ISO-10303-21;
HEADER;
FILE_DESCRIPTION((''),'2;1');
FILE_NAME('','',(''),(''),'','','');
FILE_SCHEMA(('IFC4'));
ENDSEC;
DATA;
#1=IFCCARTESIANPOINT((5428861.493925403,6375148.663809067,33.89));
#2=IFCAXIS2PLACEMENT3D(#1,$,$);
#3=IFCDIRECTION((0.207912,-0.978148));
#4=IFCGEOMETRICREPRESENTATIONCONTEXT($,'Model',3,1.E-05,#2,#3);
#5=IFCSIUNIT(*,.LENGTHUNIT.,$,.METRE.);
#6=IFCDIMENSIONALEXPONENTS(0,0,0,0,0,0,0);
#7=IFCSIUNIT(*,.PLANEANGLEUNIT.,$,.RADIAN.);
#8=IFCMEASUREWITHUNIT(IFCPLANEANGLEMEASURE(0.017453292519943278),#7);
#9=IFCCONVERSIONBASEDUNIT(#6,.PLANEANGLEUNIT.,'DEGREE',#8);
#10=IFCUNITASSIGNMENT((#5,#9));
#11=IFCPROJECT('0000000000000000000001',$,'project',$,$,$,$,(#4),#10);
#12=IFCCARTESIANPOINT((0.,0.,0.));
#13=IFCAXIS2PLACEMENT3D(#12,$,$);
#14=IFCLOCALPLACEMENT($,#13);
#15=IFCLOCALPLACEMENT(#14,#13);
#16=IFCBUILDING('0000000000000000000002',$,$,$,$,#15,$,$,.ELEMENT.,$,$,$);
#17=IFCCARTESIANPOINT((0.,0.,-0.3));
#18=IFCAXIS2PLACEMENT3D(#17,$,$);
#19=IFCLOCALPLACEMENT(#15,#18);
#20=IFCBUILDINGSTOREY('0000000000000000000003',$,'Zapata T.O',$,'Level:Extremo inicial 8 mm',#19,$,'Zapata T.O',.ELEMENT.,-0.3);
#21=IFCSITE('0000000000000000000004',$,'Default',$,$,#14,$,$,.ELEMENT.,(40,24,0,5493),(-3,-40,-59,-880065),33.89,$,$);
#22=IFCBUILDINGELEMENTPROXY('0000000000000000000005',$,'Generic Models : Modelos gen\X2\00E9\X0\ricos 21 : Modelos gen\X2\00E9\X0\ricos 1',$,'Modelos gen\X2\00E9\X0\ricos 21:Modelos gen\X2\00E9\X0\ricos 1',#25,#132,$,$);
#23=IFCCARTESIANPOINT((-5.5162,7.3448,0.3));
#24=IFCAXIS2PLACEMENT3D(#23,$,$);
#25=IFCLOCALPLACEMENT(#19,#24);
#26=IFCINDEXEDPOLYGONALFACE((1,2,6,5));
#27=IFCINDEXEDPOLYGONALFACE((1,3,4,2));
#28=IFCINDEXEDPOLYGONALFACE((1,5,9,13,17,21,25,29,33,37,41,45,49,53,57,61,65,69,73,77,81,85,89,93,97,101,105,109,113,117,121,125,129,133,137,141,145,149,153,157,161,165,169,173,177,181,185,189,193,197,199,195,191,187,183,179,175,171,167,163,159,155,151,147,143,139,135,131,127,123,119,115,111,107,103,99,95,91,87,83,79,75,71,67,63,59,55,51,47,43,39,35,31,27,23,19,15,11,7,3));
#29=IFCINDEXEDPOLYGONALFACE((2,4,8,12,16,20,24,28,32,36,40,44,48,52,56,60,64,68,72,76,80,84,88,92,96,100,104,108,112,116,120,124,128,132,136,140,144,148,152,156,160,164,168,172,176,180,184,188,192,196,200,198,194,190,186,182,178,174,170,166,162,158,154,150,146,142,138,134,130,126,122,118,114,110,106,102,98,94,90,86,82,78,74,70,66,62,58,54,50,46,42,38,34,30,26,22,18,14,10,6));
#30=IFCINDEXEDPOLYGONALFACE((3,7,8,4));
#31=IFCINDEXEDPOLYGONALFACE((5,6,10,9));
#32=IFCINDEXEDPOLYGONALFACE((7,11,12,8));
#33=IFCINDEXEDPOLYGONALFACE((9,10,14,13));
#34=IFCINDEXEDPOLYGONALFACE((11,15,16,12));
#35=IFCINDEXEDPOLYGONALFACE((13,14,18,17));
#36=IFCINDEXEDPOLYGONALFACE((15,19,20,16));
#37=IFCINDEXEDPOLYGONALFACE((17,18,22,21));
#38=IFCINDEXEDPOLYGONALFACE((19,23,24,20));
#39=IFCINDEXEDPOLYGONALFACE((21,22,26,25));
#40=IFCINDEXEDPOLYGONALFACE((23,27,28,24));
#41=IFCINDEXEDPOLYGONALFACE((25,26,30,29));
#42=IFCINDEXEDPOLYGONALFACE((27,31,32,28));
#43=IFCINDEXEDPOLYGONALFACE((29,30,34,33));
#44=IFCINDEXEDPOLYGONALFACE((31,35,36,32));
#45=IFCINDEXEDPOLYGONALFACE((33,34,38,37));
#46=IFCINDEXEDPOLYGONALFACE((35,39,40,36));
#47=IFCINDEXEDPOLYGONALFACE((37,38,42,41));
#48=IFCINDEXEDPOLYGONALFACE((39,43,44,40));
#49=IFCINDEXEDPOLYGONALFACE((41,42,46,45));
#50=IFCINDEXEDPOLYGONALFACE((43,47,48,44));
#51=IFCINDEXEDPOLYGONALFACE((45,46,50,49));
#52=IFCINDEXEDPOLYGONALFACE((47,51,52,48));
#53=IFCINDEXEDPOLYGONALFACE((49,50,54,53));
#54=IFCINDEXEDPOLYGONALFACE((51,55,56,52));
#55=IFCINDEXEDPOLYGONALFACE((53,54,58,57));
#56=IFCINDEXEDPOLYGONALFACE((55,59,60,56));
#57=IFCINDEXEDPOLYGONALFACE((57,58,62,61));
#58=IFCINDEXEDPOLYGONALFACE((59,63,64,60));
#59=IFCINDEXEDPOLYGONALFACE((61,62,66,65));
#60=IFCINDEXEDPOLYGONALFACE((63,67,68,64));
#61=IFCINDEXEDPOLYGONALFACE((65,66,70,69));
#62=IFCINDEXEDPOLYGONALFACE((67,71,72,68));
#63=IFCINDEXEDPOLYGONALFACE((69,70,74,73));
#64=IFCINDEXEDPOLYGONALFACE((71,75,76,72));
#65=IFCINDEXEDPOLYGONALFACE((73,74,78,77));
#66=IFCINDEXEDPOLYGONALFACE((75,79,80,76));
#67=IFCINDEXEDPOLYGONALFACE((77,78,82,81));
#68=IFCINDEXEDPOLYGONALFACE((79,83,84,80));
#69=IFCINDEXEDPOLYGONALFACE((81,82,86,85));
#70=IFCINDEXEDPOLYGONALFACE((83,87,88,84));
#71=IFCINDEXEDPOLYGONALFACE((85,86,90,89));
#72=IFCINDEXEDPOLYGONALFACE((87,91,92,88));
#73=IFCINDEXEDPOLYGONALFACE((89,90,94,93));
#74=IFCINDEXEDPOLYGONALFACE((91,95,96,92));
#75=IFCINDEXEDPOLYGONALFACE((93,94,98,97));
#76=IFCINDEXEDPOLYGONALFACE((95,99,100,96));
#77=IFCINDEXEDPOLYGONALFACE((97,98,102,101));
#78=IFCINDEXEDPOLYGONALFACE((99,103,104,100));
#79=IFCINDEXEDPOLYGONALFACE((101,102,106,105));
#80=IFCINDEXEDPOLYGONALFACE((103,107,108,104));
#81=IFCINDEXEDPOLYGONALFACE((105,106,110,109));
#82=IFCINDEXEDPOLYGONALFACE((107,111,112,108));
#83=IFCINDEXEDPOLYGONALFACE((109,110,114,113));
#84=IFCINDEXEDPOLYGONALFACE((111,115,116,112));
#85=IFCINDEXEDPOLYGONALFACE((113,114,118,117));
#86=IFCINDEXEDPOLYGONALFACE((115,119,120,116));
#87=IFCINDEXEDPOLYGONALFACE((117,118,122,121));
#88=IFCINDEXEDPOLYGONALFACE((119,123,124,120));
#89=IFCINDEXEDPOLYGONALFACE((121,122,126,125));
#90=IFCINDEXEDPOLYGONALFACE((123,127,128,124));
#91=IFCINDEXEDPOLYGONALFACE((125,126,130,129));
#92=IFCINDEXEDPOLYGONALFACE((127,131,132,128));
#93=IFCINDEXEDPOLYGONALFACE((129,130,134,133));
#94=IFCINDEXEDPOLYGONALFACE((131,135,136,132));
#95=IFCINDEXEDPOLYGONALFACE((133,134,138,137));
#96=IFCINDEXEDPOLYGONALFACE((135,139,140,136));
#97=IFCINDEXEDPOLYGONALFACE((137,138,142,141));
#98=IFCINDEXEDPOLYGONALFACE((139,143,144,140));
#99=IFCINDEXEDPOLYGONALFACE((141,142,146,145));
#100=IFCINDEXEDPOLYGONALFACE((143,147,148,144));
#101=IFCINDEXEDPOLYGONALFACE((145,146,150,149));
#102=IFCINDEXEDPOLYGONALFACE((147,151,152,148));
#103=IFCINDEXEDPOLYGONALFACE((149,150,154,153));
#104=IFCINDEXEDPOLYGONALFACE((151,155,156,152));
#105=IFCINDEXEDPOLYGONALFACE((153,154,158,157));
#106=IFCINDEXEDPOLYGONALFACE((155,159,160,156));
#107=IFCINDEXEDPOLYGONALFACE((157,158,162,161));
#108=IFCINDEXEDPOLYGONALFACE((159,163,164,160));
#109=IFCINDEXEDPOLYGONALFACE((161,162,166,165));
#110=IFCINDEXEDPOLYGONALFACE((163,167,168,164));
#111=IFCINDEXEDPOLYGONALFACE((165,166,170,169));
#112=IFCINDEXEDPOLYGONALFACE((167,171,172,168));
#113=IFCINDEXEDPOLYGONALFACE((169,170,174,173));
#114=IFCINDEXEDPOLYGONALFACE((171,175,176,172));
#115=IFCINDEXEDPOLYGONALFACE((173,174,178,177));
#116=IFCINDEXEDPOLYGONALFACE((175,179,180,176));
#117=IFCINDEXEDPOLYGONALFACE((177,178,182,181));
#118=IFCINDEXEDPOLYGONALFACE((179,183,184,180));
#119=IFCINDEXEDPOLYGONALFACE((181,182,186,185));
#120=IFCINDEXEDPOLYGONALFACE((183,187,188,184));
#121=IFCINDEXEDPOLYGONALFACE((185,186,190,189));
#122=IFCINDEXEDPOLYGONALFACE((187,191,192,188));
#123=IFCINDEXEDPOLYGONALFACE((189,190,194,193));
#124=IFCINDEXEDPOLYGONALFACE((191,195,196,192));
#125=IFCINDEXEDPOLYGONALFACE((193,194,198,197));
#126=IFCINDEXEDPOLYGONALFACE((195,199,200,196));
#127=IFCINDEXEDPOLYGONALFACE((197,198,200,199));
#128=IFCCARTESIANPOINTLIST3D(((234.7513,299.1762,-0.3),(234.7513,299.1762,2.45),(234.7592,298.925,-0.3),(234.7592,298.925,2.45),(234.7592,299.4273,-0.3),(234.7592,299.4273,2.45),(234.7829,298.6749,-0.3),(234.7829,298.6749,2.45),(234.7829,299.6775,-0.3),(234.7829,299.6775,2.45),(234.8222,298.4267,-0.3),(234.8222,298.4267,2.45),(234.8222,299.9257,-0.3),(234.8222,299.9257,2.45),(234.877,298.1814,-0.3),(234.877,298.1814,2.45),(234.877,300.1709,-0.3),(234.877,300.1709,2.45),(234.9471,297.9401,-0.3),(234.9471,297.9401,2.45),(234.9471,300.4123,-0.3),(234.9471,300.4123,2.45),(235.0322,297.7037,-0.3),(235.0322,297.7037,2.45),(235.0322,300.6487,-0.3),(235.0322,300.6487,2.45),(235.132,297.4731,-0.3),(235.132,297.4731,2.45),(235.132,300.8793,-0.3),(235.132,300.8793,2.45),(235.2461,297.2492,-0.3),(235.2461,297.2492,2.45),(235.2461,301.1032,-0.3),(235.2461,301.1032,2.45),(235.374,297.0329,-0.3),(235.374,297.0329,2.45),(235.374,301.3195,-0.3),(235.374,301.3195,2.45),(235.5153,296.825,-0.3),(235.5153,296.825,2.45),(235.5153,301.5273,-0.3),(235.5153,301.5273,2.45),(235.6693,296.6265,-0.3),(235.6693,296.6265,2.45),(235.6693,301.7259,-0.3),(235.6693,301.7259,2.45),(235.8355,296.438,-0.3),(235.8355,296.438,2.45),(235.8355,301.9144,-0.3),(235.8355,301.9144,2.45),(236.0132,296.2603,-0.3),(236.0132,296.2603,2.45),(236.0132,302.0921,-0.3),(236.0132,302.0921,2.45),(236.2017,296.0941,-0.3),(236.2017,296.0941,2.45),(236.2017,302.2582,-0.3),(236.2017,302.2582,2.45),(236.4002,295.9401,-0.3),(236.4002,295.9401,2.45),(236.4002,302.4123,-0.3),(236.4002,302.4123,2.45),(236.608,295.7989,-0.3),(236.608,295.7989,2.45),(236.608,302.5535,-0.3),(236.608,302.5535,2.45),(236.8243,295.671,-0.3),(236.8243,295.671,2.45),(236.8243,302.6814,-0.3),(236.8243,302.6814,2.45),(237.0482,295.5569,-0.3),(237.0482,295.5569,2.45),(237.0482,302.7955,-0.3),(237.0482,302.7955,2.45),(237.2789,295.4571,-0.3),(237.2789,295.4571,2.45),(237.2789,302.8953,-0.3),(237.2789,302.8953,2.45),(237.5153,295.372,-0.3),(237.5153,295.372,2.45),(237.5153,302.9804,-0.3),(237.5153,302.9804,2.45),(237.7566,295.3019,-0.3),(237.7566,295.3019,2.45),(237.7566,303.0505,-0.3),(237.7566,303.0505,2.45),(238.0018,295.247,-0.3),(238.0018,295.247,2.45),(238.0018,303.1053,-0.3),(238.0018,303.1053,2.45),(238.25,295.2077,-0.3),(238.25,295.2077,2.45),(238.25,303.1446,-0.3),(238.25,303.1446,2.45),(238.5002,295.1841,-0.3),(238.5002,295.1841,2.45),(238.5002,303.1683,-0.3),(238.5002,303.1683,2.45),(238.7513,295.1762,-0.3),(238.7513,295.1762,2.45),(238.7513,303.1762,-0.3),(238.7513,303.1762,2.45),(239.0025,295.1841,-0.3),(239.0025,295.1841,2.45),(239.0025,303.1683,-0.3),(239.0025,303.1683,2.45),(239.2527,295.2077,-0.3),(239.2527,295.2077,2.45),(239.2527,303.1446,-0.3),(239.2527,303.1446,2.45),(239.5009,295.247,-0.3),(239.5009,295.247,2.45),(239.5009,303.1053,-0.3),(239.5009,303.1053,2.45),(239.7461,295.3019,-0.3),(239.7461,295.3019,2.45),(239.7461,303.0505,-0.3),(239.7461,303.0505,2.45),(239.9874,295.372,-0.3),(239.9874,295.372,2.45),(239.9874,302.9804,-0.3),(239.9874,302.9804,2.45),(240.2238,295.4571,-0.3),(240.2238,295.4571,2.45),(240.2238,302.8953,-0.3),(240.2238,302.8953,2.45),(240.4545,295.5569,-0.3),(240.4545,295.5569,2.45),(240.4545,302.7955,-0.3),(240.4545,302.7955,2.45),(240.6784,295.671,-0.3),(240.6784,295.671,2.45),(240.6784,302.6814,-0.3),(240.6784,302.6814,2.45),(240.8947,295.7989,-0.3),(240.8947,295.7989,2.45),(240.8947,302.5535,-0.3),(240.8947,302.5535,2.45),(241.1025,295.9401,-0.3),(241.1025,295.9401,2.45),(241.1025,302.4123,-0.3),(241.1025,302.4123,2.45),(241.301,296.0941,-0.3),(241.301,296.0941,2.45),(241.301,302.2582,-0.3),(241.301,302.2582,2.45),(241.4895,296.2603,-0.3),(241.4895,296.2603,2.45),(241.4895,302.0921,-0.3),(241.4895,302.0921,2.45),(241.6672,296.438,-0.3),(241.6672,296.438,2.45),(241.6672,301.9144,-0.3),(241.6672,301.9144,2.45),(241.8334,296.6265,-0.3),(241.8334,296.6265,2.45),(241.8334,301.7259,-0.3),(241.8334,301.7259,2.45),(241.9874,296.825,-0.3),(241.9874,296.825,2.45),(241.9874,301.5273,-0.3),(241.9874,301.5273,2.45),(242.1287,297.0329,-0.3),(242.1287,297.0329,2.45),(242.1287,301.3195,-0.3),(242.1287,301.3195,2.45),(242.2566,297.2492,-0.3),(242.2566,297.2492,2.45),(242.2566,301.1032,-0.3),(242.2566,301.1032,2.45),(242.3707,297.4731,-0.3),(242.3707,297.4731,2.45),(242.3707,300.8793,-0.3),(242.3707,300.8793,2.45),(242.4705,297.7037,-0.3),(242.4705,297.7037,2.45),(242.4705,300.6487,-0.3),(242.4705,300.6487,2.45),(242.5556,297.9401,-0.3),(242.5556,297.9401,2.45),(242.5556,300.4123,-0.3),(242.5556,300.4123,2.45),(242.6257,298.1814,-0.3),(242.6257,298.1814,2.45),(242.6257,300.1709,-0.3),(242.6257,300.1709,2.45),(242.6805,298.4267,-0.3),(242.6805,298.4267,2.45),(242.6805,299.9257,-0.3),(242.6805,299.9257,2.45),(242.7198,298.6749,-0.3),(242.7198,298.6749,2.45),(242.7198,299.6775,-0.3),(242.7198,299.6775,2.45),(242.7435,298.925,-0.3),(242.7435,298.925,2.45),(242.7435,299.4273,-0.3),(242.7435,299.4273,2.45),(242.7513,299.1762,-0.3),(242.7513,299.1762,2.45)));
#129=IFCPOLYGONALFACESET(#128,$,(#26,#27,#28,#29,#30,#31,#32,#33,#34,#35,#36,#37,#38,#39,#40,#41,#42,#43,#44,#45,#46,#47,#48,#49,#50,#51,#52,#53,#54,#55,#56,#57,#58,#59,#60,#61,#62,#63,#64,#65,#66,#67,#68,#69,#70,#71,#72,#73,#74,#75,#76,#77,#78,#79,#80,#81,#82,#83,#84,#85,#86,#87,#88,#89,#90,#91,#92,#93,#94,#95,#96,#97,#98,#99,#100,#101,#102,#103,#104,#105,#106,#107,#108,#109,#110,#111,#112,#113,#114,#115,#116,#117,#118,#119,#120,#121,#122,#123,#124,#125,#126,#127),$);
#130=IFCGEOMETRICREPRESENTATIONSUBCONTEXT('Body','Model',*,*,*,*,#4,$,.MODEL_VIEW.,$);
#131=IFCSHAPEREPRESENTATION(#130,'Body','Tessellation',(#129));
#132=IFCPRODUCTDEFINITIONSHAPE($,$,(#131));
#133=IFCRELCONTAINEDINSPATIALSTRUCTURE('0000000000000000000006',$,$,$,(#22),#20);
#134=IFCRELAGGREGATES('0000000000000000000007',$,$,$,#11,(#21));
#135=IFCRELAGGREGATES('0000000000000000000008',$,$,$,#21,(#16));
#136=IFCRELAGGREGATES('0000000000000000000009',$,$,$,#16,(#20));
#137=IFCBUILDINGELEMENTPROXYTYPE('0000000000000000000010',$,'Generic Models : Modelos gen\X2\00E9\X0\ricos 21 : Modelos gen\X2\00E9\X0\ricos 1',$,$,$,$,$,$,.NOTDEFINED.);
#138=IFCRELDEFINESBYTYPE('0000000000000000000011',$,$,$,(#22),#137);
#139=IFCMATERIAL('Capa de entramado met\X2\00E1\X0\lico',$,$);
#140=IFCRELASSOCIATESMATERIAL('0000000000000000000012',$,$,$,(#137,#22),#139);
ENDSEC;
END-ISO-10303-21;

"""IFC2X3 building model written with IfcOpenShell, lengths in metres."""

from ifc_helpers import new_model, entity, si_unit, converted_unit, direction, frame, origin, origin_2d_with_axis, place, context, subcontext, project, spatial, circle, extrude, source, transform, mapped, material, type_object, type_shapes, element, save


model = new_model("IFC2X3")

# Units and contexts
model_context = context("Model", 3, precision=1e-05, world=frame((5428861.493925403, 6375148.663809067, 33.89)), true_north=direction((0.207912, -0.978148)))
body_context = subcontext(model_context, "Body", "Model", "MODEL_VIEW")
ifc_project = project(units=[si_unit("LENGTHUNIT", "METRE"), converted_unit("PLANEANGLEUNIT", "DEGREE", entity("IfcPlaneAngleMeasure", 0.017453292519943278), si_unit("PLANEANGLEUNIT", "RADIAN"), dimensions=[0, 0, 0, 0, 0, 0, 0])], contexts=[model_context])

# Site, building, storey
site_placement = place(None, origin())
site = spatial("IfcSite", under=ifc_project, at=site_placement, Name="Default", CompositionType="ELEMENT", RefLatitude=(40, 24, 0, 5493), RefLongitude=(-3, -40, -59, -880065), RefElevation=33.89)
building_placement = place(site_placement, origin())
building = spatial("IfcBuilding", under=site, at=building_placement, CompositionType="ELEMENT")
storey_placement = place(building_placement, frame((0.0, 0.0, -0.3)))
storey = spatial("IfcBuildingStorey", under=building, at=storey_placement, Name="Zapata T.O", ObjectType="Level:Extremo inicial 8 mm", LongName="Zapata T.O", CompositionType="ELEMENT", Elevation=-0.3)

# Building element proxy
ifc_material = material(Name="Capa de entramado metálico")
building_element_proxy_type_1 = type_object("IfcBuildingElementProxyType", Name="Generic Models : Modelos genéricos 21 : Modelos genéricos 1", PredefinedType="NOTDEFINED", material=ifc_material)
shared_shape_1 = source(origin(), body_context, "Body", "SweptSolid", [
    extrude(circle(Radius=4.0, at=origin_2d_with_axis()), frame((238.7513, 299.1762, -0.3)), (0.0, 0.0, 1.0), 2.75),
])
type_shapes(building_element_proxy_type_1, [shared_shape_1])
proxy_1_placement = place(storey_placement, frame((-5.5162, 7.3448, 0.3)))
element("IfcBuildingElementProxy", 1, at=proxy_1_placement, inside=storey, type_object=building_element_proxy_type_1, material=ifc_material, Name="Generic Models : Modelos genéricos 21 : Modelos genéricos 1", ObjectType="Modelos genéricos 21:Modelos genéricos 1", context=body_context, shape_type="MappedRepresentation", body=[
    mapped(shared_shape_1, transform((0.0, 0.0, 0.0), scale=1.0)),
])

save(model, "model.ifc")
